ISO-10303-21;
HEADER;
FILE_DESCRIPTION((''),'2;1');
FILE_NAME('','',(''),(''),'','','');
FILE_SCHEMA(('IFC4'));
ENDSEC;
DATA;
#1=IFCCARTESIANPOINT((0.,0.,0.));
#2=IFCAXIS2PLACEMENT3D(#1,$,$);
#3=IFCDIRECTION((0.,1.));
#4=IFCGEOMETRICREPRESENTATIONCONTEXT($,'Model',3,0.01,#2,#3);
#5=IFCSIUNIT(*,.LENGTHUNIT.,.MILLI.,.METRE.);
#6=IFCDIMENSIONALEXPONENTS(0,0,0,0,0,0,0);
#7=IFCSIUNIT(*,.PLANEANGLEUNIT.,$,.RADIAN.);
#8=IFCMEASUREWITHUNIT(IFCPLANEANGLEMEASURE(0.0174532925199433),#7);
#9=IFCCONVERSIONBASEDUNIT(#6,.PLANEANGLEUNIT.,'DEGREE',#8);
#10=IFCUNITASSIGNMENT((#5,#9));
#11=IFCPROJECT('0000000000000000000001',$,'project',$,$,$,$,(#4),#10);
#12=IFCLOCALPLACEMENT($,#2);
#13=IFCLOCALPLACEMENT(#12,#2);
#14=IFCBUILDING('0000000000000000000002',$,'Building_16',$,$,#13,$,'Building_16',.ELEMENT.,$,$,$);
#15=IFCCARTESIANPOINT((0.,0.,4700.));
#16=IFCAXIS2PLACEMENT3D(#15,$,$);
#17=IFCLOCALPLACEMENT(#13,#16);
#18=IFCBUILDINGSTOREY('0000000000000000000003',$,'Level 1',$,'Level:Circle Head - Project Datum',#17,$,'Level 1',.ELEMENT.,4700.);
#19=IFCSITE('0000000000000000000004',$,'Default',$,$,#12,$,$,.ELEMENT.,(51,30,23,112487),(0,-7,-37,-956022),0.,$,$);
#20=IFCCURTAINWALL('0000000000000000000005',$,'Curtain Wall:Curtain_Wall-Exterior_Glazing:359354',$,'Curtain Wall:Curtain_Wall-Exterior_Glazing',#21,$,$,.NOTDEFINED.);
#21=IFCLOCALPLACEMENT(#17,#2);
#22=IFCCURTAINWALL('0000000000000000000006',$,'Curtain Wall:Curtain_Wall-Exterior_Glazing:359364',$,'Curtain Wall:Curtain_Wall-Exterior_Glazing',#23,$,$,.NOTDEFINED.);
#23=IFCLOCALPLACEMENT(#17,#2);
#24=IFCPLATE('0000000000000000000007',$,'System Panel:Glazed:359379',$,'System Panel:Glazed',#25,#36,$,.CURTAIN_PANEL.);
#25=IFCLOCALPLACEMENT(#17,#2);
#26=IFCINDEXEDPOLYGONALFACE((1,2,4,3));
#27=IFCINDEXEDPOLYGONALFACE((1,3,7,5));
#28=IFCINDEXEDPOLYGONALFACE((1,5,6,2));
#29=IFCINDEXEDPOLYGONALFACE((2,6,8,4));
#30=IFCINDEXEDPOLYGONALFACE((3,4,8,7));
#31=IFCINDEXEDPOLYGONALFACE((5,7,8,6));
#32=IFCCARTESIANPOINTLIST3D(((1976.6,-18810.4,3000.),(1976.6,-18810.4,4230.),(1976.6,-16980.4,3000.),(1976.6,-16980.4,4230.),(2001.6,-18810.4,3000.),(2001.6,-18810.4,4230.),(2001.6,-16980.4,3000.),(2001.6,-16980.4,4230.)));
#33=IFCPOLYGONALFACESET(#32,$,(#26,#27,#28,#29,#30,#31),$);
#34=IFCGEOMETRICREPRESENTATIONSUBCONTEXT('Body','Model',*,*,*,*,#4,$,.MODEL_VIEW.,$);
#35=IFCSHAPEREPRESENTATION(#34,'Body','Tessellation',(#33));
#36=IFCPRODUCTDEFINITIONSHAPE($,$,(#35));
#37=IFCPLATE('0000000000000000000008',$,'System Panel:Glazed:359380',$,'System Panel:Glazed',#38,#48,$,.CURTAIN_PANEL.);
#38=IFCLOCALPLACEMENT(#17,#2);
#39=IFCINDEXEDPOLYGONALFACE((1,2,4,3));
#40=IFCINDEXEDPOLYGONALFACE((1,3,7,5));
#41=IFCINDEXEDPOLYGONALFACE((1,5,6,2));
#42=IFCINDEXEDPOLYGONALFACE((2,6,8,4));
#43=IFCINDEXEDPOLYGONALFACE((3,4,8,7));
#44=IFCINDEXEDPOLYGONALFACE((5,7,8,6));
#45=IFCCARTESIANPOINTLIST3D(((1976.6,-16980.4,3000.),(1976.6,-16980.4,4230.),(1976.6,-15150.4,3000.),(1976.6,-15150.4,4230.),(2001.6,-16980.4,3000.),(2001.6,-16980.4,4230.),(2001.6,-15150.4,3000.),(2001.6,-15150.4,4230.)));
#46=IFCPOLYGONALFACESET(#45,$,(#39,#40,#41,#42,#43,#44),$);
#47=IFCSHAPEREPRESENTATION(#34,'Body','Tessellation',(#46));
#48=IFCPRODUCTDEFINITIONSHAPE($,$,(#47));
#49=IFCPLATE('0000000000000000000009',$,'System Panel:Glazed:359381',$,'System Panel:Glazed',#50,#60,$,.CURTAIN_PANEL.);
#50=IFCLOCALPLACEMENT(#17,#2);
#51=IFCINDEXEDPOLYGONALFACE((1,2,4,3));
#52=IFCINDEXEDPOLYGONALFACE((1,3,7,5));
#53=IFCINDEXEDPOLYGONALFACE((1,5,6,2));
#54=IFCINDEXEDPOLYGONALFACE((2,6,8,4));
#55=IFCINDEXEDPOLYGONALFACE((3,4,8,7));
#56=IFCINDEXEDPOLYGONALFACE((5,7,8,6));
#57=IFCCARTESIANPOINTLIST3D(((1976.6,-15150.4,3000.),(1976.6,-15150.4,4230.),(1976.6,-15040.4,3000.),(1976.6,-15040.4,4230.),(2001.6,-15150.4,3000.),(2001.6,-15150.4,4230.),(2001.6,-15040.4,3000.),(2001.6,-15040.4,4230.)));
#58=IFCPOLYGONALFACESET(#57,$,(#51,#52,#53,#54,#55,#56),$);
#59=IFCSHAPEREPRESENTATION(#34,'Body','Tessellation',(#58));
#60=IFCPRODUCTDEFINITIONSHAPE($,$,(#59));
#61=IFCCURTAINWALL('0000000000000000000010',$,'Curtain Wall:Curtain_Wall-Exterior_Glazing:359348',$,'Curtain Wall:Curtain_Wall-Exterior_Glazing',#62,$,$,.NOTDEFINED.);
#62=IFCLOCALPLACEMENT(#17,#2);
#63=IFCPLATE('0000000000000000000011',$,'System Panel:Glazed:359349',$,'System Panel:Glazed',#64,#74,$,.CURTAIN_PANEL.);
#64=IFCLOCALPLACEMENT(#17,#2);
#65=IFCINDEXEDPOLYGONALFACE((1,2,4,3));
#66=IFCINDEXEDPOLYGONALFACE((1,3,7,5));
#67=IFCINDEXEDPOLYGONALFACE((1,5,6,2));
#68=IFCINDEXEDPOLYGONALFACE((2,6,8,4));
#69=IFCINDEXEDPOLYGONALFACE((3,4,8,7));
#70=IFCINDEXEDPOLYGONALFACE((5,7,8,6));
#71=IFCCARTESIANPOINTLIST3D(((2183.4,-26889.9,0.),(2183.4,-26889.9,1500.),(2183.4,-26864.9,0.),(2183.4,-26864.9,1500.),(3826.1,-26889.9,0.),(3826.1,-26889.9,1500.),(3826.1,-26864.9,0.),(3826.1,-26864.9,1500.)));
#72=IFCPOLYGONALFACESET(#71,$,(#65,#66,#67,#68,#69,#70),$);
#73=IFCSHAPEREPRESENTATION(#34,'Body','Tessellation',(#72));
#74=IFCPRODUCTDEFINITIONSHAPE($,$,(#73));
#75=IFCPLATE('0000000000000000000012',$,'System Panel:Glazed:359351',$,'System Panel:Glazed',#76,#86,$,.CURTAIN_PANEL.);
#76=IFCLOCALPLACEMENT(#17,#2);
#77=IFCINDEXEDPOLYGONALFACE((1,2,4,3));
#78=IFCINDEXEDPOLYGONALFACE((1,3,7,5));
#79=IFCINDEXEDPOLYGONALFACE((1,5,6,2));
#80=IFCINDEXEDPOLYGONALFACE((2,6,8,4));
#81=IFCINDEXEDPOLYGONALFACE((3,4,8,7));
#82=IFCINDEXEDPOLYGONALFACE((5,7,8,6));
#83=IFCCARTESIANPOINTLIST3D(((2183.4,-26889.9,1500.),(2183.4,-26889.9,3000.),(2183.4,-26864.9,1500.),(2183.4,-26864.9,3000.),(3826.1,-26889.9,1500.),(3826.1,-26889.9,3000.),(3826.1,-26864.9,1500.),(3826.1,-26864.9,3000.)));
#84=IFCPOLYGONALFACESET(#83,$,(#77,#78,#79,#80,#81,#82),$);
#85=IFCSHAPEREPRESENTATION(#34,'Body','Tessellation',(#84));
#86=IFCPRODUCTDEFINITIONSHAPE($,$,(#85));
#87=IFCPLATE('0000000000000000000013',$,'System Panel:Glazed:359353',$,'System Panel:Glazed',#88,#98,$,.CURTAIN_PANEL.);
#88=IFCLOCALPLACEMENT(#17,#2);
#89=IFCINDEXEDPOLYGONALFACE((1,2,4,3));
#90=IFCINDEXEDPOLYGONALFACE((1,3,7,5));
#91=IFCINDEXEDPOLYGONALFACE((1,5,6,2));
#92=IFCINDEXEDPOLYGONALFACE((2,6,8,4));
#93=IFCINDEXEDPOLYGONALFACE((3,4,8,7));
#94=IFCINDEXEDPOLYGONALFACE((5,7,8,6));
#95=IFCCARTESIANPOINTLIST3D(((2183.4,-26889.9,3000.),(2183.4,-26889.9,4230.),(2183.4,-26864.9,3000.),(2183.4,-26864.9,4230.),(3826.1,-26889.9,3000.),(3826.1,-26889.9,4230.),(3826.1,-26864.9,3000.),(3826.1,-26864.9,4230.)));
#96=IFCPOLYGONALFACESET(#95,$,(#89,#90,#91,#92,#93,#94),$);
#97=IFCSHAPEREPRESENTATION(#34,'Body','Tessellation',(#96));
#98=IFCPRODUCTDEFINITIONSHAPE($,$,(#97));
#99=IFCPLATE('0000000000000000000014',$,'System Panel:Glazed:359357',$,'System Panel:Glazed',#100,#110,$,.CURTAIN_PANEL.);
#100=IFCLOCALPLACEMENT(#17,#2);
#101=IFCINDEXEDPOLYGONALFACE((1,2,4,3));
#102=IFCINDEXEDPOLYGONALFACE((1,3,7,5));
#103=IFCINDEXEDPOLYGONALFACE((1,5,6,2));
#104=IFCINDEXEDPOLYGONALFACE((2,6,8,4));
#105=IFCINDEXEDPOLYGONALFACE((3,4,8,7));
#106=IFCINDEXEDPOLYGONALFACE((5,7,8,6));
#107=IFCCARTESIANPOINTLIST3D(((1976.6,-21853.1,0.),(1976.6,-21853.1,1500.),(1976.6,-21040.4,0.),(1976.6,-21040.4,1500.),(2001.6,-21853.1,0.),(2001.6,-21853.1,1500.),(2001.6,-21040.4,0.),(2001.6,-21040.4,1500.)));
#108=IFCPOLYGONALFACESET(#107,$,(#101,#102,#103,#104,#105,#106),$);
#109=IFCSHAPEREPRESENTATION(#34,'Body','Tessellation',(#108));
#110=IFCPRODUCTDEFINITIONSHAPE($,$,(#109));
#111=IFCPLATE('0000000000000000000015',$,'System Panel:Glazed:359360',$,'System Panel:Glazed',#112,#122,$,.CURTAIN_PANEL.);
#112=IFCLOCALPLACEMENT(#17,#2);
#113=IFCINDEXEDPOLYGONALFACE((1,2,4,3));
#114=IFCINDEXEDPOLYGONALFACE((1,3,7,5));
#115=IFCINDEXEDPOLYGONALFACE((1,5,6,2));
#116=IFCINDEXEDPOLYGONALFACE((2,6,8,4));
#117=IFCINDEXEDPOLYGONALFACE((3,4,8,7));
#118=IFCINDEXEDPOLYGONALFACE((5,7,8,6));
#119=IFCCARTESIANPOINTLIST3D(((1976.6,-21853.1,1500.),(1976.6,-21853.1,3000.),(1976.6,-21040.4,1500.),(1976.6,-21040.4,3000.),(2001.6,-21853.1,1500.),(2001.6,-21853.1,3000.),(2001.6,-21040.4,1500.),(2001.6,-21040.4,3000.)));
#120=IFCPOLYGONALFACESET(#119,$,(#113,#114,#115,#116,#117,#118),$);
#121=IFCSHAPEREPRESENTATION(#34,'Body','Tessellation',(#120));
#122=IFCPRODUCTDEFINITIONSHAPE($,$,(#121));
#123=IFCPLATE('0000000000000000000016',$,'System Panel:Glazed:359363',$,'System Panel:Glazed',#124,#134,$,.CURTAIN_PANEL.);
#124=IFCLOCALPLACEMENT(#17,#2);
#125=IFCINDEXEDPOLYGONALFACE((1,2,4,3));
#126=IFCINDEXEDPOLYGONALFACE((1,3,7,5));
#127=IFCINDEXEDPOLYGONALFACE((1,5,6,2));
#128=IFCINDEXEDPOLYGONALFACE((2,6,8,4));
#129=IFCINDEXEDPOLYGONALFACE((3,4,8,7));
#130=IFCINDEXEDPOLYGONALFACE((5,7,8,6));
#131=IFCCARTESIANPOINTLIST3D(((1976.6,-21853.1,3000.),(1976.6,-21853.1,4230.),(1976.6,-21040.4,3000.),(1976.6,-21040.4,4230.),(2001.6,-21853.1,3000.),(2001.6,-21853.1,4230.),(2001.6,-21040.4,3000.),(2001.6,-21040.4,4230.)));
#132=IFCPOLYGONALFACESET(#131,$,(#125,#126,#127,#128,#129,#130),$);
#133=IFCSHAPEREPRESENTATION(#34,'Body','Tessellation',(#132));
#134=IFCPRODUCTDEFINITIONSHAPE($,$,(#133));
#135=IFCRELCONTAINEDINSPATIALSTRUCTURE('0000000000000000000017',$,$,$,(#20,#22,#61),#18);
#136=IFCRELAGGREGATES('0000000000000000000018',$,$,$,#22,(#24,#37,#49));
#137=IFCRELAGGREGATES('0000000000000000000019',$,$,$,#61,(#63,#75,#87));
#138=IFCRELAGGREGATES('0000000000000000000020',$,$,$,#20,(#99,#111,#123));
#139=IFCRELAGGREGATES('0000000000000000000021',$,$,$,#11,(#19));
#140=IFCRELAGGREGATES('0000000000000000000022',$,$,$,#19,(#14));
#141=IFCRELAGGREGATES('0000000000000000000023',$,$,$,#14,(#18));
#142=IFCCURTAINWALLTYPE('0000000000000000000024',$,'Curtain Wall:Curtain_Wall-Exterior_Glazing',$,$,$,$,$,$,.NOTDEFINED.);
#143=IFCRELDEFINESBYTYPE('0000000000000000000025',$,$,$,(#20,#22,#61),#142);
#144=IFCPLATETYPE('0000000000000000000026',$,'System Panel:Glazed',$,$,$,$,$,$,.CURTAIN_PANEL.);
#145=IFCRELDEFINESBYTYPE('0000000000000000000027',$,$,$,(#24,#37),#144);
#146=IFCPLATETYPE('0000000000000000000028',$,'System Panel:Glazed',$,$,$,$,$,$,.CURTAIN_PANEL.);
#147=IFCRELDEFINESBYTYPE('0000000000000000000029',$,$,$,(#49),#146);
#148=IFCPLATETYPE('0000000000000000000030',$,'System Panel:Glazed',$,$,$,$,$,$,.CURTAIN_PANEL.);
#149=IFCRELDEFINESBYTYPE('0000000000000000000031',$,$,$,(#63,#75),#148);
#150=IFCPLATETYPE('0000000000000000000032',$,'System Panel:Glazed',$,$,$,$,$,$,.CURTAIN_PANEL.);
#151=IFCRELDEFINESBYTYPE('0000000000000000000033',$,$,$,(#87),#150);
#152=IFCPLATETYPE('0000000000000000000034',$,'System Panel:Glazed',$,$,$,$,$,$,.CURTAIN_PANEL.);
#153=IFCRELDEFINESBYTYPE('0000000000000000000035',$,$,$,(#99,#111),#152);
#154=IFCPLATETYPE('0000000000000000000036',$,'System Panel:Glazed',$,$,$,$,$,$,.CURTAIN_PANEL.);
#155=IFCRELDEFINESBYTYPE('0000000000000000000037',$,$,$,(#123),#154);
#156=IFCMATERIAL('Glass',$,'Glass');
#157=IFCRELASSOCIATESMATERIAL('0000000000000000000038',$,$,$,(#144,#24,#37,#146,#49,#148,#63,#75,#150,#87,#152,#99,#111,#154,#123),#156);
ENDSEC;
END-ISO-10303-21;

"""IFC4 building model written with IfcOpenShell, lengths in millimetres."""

from ifc_helpers import new_model, entity, si_unit, converted_unit, direction, frame, origin, place, context, subcontext, project, spatial, indexed_curve, outline, extrude, source, transform, mapped, material, type_object, type_shapes, element, aggregate, save


model = new_model("IFC4")

# Units and contexts
model_context = context("Model", 3, precision=0.01, world=origin(), true_north=direction((0.0, 1.0)))
body_context = subcontext(model_context, "Body", "Model", "MODEL_VIEW")
ifc_project = project(units=[si_unit("LENGTHUNIT", "METRE", prefix="MILLI"), converted_unit("PLANEANGLEUNIT", "DEGREE", entity("IfcPlaneAngleMeasure", 0.0174532925199433), si_unit("PLANEANGLEUNIT", "RADIAN"), dimensions=[0, 0, 0, 0, 0, 0, 0])], contexts=[model_context])

# Site, building, storey
site_placement = place(None, origin())
site = spatial("IfcSite", under=ifc_project, at=site_placement, Name="Default", CompositionType="ELEMENT", RefLatitude=(51, 30, 23, 112487), RefLongitude=(0, -7, -37, -956022), RefElevation=0.0)
building_placement = place(site_placement, origin())
building = spatial("IfcBuilding", under=site, at=building_placement, Name="Building_16", LongName="Building_16", CompositionType="ELEMENT")
storey_placement = place(building_placement, frame((0.0, 0.0, 4700.0)))
storey = spatial("IfcBuildingStorey", under=building, at=storey_placement, Name="Level 1", ObjectType="Level:Circle Head - Project Datum", LongName="Level 1", CompositionType="ELEMENT", Elevation=4700.0)

# Curtain walls
curtain_wall_type = type_object("IfcCurtainWallType", Name="Curtain Wall:Curtain_Wall-Exterior_Glazing", PredefinedType="NOTDEFINED")
curtain_wall_1_placement = place(storey_placement, frame((0.0, 0.0, -4700.0)))
curtain_wall_1 = element("IfcCurtainWall", 1, at=curtain_wall_1_placement, inside=storey, type_object=curtain_wall_type, Name="Curtain Wall:Curtain_Wall-Exterior_Glazing:359354", ObjectType="Curtain Wall:Curtain_Wall-Exterior_Glazing", PredefinedType="NOTDEFINED")
ifc_material_1 = material(Name="Glass", Category="Glass")
curtain_wall_2_placement = place(storey_placement, frame((0.0, 0.0, -4700.0)))
curtain_wall_2 = element("IfcCurtainWall", 2, at=curtain_wall_2_placement, inside=storey, type_object=curtain_wall_type, Name="Curtain Wall:Curtain_Wall-Exterior_Glazing:359364", ObjectType="Curtain Wall:Curtain_Wall-Exterior_Glazing", PredefinedType="NOTDEFINED")

# Plates
plate_type_1 = type_object("IfcPlateType", Name="System Panel:Glazed", PredefinedType="CURTAIN_PANEL", material=ifc_material_1)
shared_shape_1 = source(origin(), body_context, "Body", "SweptSolid", [
    extrude(outline(indexed_curve([(-12.5, -915.0), (12.5, -915.0), (12.5, 915.0), (-12.5, 915.0), (-12.5, -915.0)], self_intersect=False)), frame((0.0, 37.0, 0.0), z_axis=(0.0, 0.0, 1.0), x_axis=(0.0, 1.0, 0.0)), (0.0, 0.0, 1.0), 1230.0),
])
type_shapes(plate_type_1, [shared_shape_1])
plate_1_placement = place(curtain_wall_2_placement, frame((2026.1, -17895.4, 7700.0), z_axis=(0.0, 0.0, 1.0), x_axis=(0.0, 1.0, 0.0)))
plate_1 = element("IfcPlate", 3, at=plate_1_placement, type_object=plate_type_1, material=ifc_material_1, Name="System Panel:Glazed:359379", ObjectType="System Panel:Glazed", PredefinedType="CURTAIN_PANEL", context=body_context, shape_type="MappedRepresentation", body=[
    mapped(shared_shape_1, transform((0.0, 0.0, 0.0), scale=1.0)),
])
plate_2_placement = place(curtain_wall_2_placement, frame((2026.1, -16065.4, 7700.0), z_axis=(0.0, 0.0, 1.0), x_axis=(0.0, 1.0, 0.0)))
plate_2 = element("IfcPlate", 4, at=plate_2_placement, type_object=plate_type_1, material=ifc_material_1, Name="System Panel:Glazed:359380", ObjectType="System Panel:Glazed", PredefinedType="CURTAIN_PANEL", context=body_context, shape_type="MappedRepresentation", body=[
    mapped(shared_shape_1, transform((0.0, 0.0, 0.0), scale=1.0)),
])
plate_type_2 = type_object("IfcPlateType", Name="System Panel:Glazed", PredefinedType="CURTAIN_PANEL", material=ifc_material_1)
shared_shape_2 = source(origin(), body_context, "Body", "SweptSolid", [
    extrude(outline(indexed_curve([(-12.5, -55.0), (12.5, -55.0), (12.5, 55.0), (-12.5, 55.0), (-12.5, -55.0)], self_intersect=False)), frame((0.0, 37.0, 0.0), z_axis=(0.0, 0.0, 1.0), x_axis=(0.0, 1.0, 0.0)), (0.0, 0.0, 1.0), 1230.0),
])
type_shapes(plate_type_2, [shared_shape_2])
plate_3_placement = place(curtain_wall_2_placement, frame((2026.1, -15095.4, 7700.0), z_axis=(0.0, 0.0, 1.0), x_axis=(0.0, 1.0, 0.0)))
plate_3 = element("IfcPlate", 5, at=plate_3_placement, type_object=plate_type_2, material=ifc_material_1, Name="System Panel:Glazed:359381", ObjectType="System Panel:Glazed", PredefinedType="CURTAIN_PANEL", context=body_context, shape_type="MappedRepresentation", body=[
    mapped(shared_shape_2, transform((0.0, 0.0, 0.0), scale=1.0)),
])
aggregate(curtain_wall_2, [plate_1, plate_2, plate_3])

# Curtain wall, plates
curtain_wall_3_placement = place(storey_placement, frame((0.0, 0.0, -4700.0)))
curtain_wall_3 = element("IfcCurtainWall", 6, at=curtain_wall_3_placement, inside=storey, type_object=curtain_wall_type, Name="Curtain Wall:Curtain_Wall-Exterior_Glazing:359348", ObjectType="Curtain Wall:Curtain_Wall-Exterior_Glazing", PredefinedType="NOTDEFINED")
plate_type_3 = type_object("IfcPlateType", Name="System Panel:Glazed", PredefinedType="CURTAIN_PANEL", material=ifc_material_1)
shared_shape_3 = source(origin(), body_context, "Body", "SweptSolid", [
    extrude(outline(indexed_curve([(-12.5, -821.4), (12.5, -821.4), (12.5, 821.4), (-12.5, 821.4), (-12.5, -821.4)], self_intersect=False)), frame((0.0, 37.0, 0.0), z_axis=(0.0, 0.0, 1.0), x_axis=(0.0, 1.0, 0.0)), (0.0, 0.0, 1.0), 1500.0),
])
type_shapes(plate_type_3, [shared_shape_3])
plate_4_placement = place(curtain_wall_3_placement, frame((3004.7, -26840.4, 4700.0), z_axis=(0.0, 0.0, 1.0), x_axis=(-1.0, 0.0, 0.0)))
plate_4 = element("IfcPlate", 7, at=plate_4_placement, type_object=plate_type_3, material=ifc_material_1, Name="System Panel:Glazed:359349", ObjectType="System Panel:Glazed", PredefinedType="CURTAIN_PANEL", context=body_context, shape_type="MappedRepresentation", body=[
    mapped(shared_shape_3, transform((0.0, 0.0, 0.0), scale=1.0)),
])
plate_5_placement = place(curtain_wall_3_placement, frame((3004.7, -26840.4, 6200.0), z_axis=(0.0, 0.0, 1.0), x_axis=(-1.0, 0.0, 0.0)))
plate_5 = element("IfcPlate", 8, at=plate_5_placement, type_object=plate_type_3, material=ifc_material_1, Name="System Panel:Glazed:359351", ObjectType="System Panel:Glazed", PredefinedType="CURTAIN_PANEL", context=body_context, shape_type="MappedRepresentation", body=[
    mapped(shared_shape_3, transform((0.0, 0.0, 0.0), scale=1.0)),
])
plate_type_4 = type_object("IfcPlateType", Name="System Panel:Glazed", PredefinedType="CURTAIN_PANEL", material=ifc_material_1)
shared_shape_4 = source(origin(), body_context, "Body", "SweptSolid", [
    extrude(outline(indexed_curve([(-12.5, -821.4), (12.5, -821.4), (12.5, 821.4), (-12.5, 821.4), (-12.5, -821.4)], self_intersect=False)), frame((0.0, 37.0, 0.0), z_axis=(0.0, 0.0, 1.0), x_axis=(0.0, 1.0, 0.0)), (0.0, 0.0, 1.0), 1230.0),
])
type_shapes(plate_type_4, [shared_shape_4])
plate_6_placement = place(curtain_wall_3_placement, frame((3004.7, -26840.4, 7700.0), z_axis=(0.0, 0.0, 1.0), x_axis=(-1.0, 0.0, 0.0)))
plate_6 = element("IfcPlate", 9, at=plate_6_placement, type_object=plate_type_4, material=ifc_material_1, Name="System Panel:Glazed:359353", ObjectType="System Panel:Glazed", PredefinedType="CURTAIN_PANEL", context=body_context, shape_type="MappedRepresentation", body=[
    mapped(shared_shape_4, transform((0.0, 0.0, 0.0), scale=1.0)),
])
aggregate(curtain_wall_3, [plate_4, plate_5, plate_6])

# Plates
plate_type_5 = type_object("IfcPlateType", Name="System Panel:Glazed", PredefinedType="CURTAIN_PANEL", material=ifc_material_1)
shared_shape_5 = source(origin(), body_context, "Body", "SweptSolid", [
    extrude(outline(indexed_curve([(-12.5, -406.4), (12.5, -406.4), (12.5, 406.4), (-12.5, 406.4), (-12.5, -406.4)], self_intersect=False)), frame((0.0, 37.0, 0.0), z_axis=(0.0, 0.0, 1.0), x_axis=(0.0, 1.0, 0.0)), (0.0, 0.0, 1.0), 1500.0),
])
type_shapes(plate_type_5, [shared_shape_5])
plate_7_placement = place(curtain_wall_1_placement, frame((2026.1, -21446.7, 4700.0), z_axis=(0.0, 0.0, 1.0), x_axis=(0.0, 1.0, 0.0)))
plate_7 = element("IfcPlate", 10, at=plate_7_placement, type_object=plate_type_5, material=ifc_material_1, Name="System Panel:Glazed:359357", ObjectType="System Panel:Glazed", PredefinedType="CURTAIN_PANEL", context=body_context, shape_type="MappedRepresentation", body=[
    mapped(shared_shape_5, transform((0.0, 0.0, 0.0), scale=1.0)),
])
plate_8_placement = place(curtain_wall_1_placement, frame((2026.1, -21446.7, 6200.0), z_axis=(0.0, 0.0, 1.0), x_axis=(0.0, 1.0, 0.0)))
plate_8 = element("IfcPlate", 11, at=plate_8_placement, type_object=plate_type_5, material=ifc_material_1, Name="System Panel:Glazed:359360", ObjectType="System Panel:Glazed", PredefinedType="CURTAIN_PANEL", context=body_context, shape_type="MappedRepresentation", body=[
    mapped(shared_shape_5, transform((0.0, 0.0, 0.0), scale=1.0)),
])
plate_type_6 = type_object("IfcPlateType", Name="System Panel:Glazed", PredefinedType="CURTAIN_PANEL", material=ifc_material_1)
shared_shape_6 = source(origin(), body_context, "Body", "SweptSolid", [
    extrude(outline(indexed_curve([(-12.5, -406.4), (12.5, -406.4), (12.5, 406.4), (-12.5, 406.4), (-12.5, -406.4)], self_intersect=False)), frame((0.0, 37.0, 0.0), z_axis=(0.0, 0.0, 1.0), x_axis=(0.0, 1.0, 0.0)), (0.0, 0.0, 1.0), 1230.0),
])
type_shapes(plate_type_6, [shared_shape_6])
plate_9_placement = place(curtain_wall_1_placement, frame((2026.1, -21446.7, 7700.0), z_axis=(0.0, 0.0, 1.0), x_axis=(0.0, 1.0, 0.0)))
plate_9 = element("IfcPlate", 12, at=plate_9_placement, type_object=plate_type_6, material=ifc_material_1, Name="System Panel:Glazed:359363", ObjectType="System Panel:Glazed", PredefinedType="CURTAIN_PANEL", context=body_context, shape_type="MappedRepresentation", body=[
    mapped(shared_shape_6, transform((0.0, 0.0, 0.0), scale=1.0)),
])
aggregate(curtain_wall_1, [plate_7, plate_8, plate_9])

save(model, "model.ifc")
